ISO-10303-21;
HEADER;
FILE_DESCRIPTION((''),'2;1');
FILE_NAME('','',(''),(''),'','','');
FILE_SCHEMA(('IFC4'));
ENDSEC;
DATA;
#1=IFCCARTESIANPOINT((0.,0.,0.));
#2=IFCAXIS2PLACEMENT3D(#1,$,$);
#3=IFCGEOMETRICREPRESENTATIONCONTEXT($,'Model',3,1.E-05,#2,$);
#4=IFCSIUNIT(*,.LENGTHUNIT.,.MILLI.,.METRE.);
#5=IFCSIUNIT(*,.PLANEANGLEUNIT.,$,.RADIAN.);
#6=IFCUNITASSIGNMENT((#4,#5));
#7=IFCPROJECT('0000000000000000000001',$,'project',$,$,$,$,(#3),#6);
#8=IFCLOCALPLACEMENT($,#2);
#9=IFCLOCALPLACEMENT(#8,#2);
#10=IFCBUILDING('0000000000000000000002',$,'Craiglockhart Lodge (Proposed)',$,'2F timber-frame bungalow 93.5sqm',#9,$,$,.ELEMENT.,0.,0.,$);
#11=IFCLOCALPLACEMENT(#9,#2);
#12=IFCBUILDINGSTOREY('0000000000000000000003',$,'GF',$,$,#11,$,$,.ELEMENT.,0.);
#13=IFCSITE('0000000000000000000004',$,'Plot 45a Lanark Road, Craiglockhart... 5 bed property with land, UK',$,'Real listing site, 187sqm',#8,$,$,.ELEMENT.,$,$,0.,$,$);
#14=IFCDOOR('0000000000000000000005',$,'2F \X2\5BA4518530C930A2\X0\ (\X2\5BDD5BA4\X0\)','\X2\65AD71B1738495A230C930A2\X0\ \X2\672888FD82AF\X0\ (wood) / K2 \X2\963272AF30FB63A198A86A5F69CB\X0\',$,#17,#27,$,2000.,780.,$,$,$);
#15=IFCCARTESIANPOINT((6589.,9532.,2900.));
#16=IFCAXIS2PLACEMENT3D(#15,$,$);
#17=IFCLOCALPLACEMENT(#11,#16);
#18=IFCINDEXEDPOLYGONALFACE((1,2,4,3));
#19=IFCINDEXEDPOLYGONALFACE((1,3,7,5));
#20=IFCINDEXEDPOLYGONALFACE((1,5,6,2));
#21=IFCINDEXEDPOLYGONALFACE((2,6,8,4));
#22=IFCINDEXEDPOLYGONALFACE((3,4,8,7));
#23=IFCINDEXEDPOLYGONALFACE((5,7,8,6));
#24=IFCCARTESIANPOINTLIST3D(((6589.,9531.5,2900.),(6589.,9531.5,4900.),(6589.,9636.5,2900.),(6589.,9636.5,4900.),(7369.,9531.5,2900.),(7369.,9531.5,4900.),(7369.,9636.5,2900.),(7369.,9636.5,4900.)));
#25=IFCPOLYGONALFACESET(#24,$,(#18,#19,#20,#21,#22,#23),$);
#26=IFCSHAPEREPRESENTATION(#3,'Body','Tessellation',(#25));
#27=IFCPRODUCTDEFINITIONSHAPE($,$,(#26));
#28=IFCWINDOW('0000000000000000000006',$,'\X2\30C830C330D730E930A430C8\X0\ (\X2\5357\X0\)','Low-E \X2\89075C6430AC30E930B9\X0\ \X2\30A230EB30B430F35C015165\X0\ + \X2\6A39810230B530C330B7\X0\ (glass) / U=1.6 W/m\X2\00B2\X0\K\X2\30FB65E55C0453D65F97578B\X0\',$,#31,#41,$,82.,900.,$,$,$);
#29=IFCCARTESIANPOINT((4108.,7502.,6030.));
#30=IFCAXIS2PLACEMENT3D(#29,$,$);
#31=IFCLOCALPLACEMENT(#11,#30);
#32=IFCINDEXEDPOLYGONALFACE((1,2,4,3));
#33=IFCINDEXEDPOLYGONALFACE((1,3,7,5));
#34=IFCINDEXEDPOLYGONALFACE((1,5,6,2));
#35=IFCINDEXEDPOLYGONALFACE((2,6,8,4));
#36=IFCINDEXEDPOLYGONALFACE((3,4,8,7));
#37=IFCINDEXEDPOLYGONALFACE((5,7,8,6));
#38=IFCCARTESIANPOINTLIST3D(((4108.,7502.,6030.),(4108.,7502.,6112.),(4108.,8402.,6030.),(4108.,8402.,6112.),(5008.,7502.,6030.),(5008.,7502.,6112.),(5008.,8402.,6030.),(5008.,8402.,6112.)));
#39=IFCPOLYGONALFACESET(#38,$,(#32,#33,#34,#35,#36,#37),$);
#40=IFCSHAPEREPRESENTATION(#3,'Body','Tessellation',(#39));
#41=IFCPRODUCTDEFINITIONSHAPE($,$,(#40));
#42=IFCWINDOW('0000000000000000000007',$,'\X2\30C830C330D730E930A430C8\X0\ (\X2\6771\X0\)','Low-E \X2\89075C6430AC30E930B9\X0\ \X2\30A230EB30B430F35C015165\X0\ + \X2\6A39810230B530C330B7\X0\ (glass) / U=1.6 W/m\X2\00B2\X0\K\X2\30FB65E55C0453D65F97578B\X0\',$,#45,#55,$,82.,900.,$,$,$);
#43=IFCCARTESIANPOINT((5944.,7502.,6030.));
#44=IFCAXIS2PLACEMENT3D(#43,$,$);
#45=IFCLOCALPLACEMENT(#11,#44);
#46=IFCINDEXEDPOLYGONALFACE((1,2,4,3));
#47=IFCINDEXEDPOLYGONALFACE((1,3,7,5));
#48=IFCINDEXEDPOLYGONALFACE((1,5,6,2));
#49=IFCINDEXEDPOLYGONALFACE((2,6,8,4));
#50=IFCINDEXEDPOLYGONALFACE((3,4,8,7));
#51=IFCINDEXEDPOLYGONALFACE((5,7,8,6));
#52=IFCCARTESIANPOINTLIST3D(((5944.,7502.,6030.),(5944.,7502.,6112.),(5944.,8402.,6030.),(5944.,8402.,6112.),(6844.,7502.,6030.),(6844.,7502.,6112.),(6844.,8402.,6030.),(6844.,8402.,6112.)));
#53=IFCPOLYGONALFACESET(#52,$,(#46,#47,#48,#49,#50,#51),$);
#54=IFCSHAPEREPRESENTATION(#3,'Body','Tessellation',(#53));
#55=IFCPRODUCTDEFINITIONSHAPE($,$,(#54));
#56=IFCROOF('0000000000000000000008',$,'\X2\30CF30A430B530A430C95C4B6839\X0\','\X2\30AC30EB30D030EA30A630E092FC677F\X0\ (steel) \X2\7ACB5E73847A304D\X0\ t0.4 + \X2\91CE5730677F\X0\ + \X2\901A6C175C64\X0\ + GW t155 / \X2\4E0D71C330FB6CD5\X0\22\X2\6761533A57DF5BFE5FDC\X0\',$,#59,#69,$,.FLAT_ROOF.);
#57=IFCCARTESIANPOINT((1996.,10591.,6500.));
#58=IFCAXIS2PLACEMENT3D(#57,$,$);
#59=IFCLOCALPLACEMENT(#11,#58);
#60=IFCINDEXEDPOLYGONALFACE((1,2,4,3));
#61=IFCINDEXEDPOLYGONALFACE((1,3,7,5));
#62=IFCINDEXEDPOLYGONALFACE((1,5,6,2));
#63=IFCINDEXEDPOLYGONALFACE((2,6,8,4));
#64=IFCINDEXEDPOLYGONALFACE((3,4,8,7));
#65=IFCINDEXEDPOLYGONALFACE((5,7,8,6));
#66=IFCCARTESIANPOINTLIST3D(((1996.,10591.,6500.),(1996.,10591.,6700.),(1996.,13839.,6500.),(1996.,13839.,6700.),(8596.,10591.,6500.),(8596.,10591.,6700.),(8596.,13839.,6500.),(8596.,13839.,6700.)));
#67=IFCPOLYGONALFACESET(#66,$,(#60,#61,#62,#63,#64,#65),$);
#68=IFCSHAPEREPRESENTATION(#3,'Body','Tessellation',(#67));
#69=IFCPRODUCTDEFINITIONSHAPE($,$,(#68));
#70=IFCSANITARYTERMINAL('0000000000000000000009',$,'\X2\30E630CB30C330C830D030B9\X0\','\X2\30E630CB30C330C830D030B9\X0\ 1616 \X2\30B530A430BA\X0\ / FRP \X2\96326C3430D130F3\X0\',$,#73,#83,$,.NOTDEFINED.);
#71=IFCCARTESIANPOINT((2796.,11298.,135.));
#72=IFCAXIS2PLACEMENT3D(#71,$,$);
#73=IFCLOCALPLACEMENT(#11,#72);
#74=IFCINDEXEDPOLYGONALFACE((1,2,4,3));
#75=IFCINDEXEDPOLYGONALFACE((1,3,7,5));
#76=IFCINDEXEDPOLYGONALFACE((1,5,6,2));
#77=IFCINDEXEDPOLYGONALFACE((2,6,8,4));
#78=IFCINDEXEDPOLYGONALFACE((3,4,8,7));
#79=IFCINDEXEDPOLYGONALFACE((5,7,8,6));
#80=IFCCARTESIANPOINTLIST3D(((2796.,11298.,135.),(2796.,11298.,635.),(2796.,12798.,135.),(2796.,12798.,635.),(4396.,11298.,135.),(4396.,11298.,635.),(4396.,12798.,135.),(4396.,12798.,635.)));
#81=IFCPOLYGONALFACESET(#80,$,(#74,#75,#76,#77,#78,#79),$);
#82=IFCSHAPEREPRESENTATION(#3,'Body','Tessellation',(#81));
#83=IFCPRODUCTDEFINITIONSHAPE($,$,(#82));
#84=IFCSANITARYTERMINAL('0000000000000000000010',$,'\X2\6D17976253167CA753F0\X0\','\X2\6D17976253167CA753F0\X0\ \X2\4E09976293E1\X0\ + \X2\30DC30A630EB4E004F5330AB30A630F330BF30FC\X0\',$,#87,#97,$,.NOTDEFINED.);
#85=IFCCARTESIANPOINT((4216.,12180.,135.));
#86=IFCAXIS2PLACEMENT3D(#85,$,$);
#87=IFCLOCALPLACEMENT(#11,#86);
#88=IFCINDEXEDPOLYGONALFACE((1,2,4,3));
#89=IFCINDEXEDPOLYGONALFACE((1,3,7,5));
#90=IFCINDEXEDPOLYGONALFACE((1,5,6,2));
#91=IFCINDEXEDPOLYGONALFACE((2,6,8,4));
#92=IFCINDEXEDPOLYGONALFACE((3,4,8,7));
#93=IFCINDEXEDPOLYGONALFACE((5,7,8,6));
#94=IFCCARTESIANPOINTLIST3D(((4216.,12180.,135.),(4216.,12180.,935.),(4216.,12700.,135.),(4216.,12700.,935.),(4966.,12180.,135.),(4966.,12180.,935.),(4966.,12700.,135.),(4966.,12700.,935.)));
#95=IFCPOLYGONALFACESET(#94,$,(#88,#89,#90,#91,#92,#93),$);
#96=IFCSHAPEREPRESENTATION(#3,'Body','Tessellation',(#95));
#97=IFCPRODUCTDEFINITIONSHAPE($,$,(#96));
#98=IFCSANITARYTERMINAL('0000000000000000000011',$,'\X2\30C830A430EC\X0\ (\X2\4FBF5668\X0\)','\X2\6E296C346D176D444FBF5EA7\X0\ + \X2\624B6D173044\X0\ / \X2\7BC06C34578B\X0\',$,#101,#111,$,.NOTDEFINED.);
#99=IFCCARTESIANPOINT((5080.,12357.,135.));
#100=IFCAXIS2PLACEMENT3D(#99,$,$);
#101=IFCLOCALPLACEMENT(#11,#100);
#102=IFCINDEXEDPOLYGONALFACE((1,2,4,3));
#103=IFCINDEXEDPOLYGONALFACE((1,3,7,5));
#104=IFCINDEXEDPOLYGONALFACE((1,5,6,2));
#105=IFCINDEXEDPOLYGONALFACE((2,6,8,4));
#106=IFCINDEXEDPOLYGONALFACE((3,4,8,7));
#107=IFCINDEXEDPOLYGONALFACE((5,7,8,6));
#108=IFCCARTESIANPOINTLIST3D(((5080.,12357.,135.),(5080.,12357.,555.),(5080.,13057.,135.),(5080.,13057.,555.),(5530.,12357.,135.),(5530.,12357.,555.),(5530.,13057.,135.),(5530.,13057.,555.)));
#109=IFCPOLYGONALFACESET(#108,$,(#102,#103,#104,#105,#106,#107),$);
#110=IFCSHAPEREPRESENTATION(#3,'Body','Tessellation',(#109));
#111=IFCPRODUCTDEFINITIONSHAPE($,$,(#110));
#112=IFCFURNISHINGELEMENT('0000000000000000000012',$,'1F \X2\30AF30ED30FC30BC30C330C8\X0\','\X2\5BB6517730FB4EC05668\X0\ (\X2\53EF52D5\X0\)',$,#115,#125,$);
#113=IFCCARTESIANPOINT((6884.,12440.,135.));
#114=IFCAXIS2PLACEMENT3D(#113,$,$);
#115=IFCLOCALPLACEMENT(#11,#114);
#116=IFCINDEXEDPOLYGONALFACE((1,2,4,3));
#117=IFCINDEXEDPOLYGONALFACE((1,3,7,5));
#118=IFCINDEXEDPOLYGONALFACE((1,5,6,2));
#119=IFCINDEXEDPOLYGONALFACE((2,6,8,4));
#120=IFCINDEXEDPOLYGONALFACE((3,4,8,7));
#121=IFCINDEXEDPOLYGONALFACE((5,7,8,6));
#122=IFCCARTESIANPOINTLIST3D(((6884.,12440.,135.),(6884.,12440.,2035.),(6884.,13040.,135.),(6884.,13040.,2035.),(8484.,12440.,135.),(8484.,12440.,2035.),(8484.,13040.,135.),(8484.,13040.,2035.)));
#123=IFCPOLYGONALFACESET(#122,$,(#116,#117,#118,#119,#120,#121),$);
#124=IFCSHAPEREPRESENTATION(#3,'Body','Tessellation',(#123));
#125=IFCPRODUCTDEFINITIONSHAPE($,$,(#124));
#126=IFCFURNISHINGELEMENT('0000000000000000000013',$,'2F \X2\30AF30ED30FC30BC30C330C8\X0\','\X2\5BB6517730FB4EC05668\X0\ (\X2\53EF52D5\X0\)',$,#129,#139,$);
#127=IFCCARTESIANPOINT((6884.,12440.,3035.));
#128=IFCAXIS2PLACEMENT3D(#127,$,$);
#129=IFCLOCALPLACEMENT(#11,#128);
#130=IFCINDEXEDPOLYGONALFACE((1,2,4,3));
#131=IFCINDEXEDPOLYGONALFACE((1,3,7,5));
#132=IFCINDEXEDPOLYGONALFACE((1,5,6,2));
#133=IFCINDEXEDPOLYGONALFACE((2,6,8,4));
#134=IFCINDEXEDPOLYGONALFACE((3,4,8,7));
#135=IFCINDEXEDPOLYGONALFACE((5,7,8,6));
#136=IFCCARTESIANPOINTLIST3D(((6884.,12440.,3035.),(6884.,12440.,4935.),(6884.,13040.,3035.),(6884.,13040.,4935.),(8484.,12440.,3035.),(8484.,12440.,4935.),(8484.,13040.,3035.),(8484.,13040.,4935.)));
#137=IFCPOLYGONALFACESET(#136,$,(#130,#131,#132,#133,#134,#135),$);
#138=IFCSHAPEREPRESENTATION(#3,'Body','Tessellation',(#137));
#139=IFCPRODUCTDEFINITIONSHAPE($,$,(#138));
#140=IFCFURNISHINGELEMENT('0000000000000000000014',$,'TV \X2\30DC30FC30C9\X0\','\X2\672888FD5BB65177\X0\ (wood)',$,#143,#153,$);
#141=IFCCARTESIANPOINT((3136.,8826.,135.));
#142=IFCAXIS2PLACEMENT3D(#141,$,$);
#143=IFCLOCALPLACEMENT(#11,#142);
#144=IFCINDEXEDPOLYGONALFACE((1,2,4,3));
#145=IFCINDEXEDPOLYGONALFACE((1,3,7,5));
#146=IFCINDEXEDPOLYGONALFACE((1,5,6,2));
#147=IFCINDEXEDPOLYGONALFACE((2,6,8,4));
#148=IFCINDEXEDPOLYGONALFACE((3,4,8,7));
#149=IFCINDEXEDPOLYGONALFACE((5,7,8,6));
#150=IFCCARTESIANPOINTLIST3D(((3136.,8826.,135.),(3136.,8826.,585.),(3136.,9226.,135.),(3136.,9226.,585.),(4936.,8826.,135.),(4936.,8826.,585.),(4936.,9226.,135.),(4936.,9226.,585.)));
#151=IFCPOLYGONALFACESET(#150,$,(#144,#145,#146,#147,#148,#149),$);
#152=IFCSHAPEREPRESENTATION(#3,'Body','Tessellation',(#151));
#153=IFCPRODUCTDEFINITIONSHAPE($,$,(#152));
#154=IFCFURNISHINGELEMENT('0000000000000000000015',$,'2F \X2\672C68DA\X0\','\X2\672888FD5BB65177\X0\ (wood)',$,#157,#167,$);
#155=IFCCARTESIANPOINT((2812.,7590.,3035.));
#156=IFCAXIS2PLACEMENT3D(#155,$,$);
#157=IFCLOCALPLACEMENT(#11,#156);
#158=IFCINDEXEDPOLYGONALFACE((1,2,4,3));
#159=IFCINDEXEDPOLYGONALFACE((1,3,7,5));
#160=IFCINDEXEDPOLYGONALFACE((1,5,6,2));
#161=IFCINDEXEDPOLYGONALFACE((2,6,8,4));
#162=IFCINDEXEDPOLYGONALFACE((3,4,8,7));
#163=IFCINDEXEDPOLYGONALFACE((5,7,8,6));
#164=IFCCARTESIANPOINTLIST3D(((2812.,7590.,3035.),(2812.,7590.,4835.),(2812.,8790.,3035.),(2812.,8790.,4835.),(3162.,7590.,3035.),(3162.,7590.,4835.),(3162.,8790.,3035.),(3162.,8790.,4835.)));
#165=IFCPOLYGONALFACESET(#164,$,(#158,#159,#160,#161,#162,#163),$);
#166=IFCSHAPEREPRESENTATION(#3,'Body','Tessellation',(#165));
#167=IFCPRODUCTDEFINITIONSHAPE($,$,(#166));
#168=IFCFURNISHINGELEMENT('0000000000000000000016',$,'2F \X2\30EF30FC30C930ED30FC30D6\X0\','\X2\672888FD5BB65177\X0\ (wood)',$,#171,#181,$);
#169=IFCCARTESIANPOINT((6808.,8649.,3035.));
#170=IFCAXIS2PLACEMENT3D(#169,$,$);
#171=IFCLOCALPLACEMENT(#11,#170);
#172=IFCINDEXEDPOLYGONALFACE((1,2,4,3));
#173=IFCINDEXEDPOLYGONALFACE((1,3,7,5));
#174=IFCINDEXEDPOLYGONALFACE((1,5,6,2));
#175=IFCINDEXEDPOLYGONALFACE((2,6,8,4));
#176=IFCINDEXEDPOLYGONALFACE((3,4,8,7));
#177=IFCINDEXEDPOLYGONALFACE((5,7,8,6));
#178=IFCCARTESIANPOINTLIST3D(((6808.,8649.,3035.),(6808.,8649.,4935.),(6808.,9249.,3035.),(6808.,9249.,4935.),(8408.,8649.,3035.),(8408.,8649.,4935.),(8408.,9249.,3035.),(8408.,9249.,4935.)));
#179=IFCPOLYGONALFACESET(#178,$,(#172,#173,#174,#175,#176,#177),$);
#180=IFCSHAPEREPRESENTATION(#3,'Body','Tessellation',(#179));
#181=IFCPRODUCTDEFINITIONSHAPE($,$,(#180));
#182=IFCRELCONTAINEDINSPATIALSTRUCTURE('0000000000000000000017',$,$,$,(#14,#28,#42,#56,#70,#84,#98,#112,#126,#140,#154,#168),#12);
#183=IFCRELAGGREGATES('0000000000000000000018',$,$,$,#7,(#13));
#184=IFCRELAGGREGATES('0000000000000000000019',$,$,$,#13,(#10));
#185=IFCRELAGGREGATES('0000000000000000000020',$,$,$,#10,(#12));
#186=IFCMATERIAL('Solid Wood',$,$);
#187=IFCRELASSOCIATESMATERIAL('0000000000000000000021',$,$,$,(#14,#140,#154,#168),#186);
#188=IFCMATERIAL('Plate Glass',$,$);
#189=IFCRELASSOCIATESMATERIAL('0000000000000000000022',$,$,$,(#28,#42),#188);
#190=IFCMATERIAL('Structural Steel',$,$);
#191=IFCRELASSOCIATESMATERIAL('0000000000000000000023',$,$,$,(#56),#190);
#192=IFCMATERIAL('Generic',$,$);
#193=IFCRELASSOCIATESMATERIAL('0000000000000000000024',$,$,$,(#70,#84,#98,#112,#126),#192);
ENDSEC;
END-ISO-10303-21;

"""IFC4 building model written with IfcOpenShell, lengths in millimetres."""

from ifc_helpers import new_model, si_unit, frame, frame_2d, origin, place, context, project, spatial, rectangle, extrude, material, element, save


model = new_model("IFC4")

# Units and contexts
model_context = context("Model", 3, precision=1e-05, world=origin())
ifc_project = project(units=[si_unit("LENGTHUNIT", "METRE", prefix="MILLI"), si_unit("PLANEANGLEUNIT", "RADIAN")], contexts=[model_context])

# Site, building, storey
site_placement = place(None, origin())
site = spatial("IfcSite", under=ifc_project, at=site_placement, Name="Plot 45a Lanark Road, Craiglockhart... 5 bed property with land, UK", ObjectType="Real listing site, 187sqm", CompositionType="ELEMENT", RefElevation=0.0)
building_placement = place(site_placement, origin())
building = spatial("IfcBuilding", under=site, at=building_placement, Name="Craiglockhart Lodge (Proposed)", ObjectType="2F timber-frame bungalow 93.5sqm", CompositionType="ELEMENT", ElevationOfRefHeight=0.0, ElevationOfTerrain=0.0)
storey_placement = place(building_placement, origin())
storey = spatial("IfcBuildingStorey", under=building, at=storey_placement, Name="GF", CompositionType="ELEMENT", Elevation=0.0)

# Shared definitions
ifc_material_1 = material(Name="Solid Wood")
ifc_material_2 = material(Name="Plate Glass")

# Door
door_1_placement = place(storey_placement, frame((6589.0, 9532.0, 2900.0)))
element("IfcDoor", 1, at=door_1_placement, inside=storey, material=ifc_material_1, Name="2F 室内ドア (寝室)", Description="断熱玄関ドア 木製芯 (wood) / K2 防犯・採風機構", OverallHeight=2000.0, OverallWidth=780.0, context=model_context, shape_type="SweptSolid", body=[
    extrude(rectangle(XDim=780.0, YDim=105.0, at=frame_2d((390.0, 52.0))), frame((6589.0, 9532.0, 2900.0)), (0.0, 0.0, 1.0), 2000.0),
])

# Windows
window_1_placement = place(storey_placement, frame((4108.0, 7502.0, 6030.0)))
element("IfcWindow", 2, at=window_1_placement, inside=storey, material=ifc_material_2, Name="トップライト (南)", Description="Low-E 複層ガラス アルゴン封入 + 樹脂サッシ (glass) / U=1.6 W/m²K・日射取得型", OverallHeight=82.0, OverallWidth=900.0, context=model_context, shape_type="SweptSolid", body=[
    extrude(rectangle(XDim=900.0, YDim=900.0, at=frame_2d((450.0, 450.0))), frame((4108.0, 7502.0, 6030.0)), (0.0, 0.0, 1.0), 82.0),
])
window_2_placement = place(storey_placement, frame((5944.0, 7502.0, 6030.0)))
element("IfcWindow", 3, at=window_2_placement, inside=storey, material=ifc_material_2, Name="トップライト (東)", Description="Low-E 複層ガラス アルゴン封入 + 樹脂サッシ (glass) / U=1.6 W/m²K・日射取得型", OverallHeight=82.0, OverallWidth=900.0, context=model_context, shape_type="SweptSolid", body=[
    extrude(rectangle(XDim=900.0, YDim=900.0, at=frame_2d((450.0, 450.0))), frame((5944.0, 7502.0, 6030.0)), (0.0, 0.0, 1.0), 82.0),
])

# Roof
ifc_material_3 = material(Name="Structural Steel")
roof_placement = place(storey_placement, frame((1996.0, 10591.0, 6500.0)))
element("IfcRoof", 4, at=roof_placement, inside=storey, material=ifc_material_3, Name="ハイサイド屋根", Description="ガルバリウム鋼板 (steel) 立平葺き t0.4 + 野地板 + 通気層 + GW t155 / 不燃・法22条区域対応", PredefinedType="FLAT_ROOF", context=model_context, shape_type="SweptSolid", body=[
    extrude(rectangle(XDim=6600.0, YDim=3248.0, at=frame_2d((3300.0, 1624.0))), frame((1996.0, 10591.0, 6500.0)), (0.0, 0.0, 1.0), 200.0),
])

# Sanitary terminals
ifc_material_4 = material(Name="Generic")
sanitary_terminal_1_placement = place(storey_placement, frame((2796.0, 11298.0, 135.0)))
element("IfcSanitaryTerminal", 5, at=sanitary_terminal_1_placement, inside=storey, material=ifc_material_4, Name="ユニットバス", Description="ユニットバス 1616 サイズ / FRP 防水パン", PredefinedType="NOTDEFINED", context=model_context, shape_type="SweptSolid", body=[
    extrude(rectangle(XDim=1600.0, YDim=1500.0, at=frame_2d((800.0, 750.0))), frame((2796.0, 11298.0, 135.0)), (0.0, 0.0, 1.0), 500.0),
])
sanitary_terminal_2_placement = place(storey_placement, frame((4216.0, 12180.0, 135.0)))
element("IfcSanitaryTerminal", 6, at=sanitary_terminal_2_placement, inside=storey, material=ifc_material_4, Name="洗面化粧台", Description="洗面化粧台 三面鏡 + ボウル一体カウンター", PredefinedType="NOTDEFINED", context=model_context, shape_type="SweptSolid", body=[
    extrude(rectangle(XDim=750.0, YDim=520.0, at=frame_2d((375.0, 260.0))), frame((4216.0, 12180.0, 135.0)), (0.0, 0.0, 1.0), 800.0),
])
sanitary_terminal_3_placement = place(storey_placement, frame((5080.0, 12357.0, 135.0)))
element("IfcSanitaryTerminal", 7, at=sanitary_terminal_3_placement, inside=storey, material=ifc_material_4, Name="トイレ (便器)", Description="温水洗浄便座 + 手洗い / 節水型", PredefinedType="NOTDEFINED", context=model_context, shape_type="SweptSolid", body=[
    extrude(rectangle(XDim=450.0, YDim=700.0, at=frame_2d((225.0, 350.0))), frame((5080.0, 12357.0, 135.0)), (0.0, 0.0, 1.0), 420.0),
])

# Furnishing elements
furnishing_1_placement = place(storey_placement, frame((6884.0, 12440.0, 135.0)))
element("IfcFurnishingElement", 8, at=furnishing_1_placement, inside=storey, material=ifc_material_4, Name="1F クローゼット", Description="家具・什器 (可動)", context=model_context, shape_type="SweptSolid", body=[
    extrude(rectangle(XDim=1600.0, YDim=600.0, at=frame_2d((800.0, 300.0))), frame((6884.0, 12440.0, 135.0)), (0.0, 0.0, 1.0), 1900.0),
])
furnishing_2_placement = place(storey_placement, frame((6884.0, 12440.0, 3035.0)))
element("IfcFurnishingElement", 9, at=furnishing_2_placement, inside=storey, material=ifc_material_4, Name="2F クローゼット", Description="家具・什器 (可動)", context=model_context, shape_type="SweptSolid", body=[
    extrude(rectangle(XDim=1600.0, YDim=600.0, at=frame_2d((800.0, 300.0))), frame((6884.0, 12440.0, 3035.0)), (0.0, 0.0, 1.0), 1900.0),
])
furnishing_3_placement = place(storey_placement, frame((3136.0, 8826.0, 135.0)))
element("IfcFurnishingElement", 10, at=furnishing_3_placement, inside=storey, material=ifc_material_1, Name="TV ボード", Description="木製家具 (wood)", context=model_context, shape_type="SweptSolid", body=[
    extrude(rectangle(XDim=1800.0, YDim=400.0, at=frame_2d((900.0, 200.0))), frame((3136.0, 8826.0, 135.0)), (0.0, 0.0, 1.0), 450.0),
])
furnishing_4_placement = place(storey_placement, frame((2812.0, 7590.0, 3035.0)))
element("IfcFurnishingElement", 11, at=furnishing_4_placement, inside=storey, material=ifc_material_1, Name="2F 本棚", Description="木製家具 (wood)", context=model_context, shape_type="SweptSolid", body=[
    extrude(rectangle(XDim=350.0, YDim=1200.0, at=frame_2d((175.0, 600.0))), frame((2812.0, 7590.0, 3035.0)), (0.0, 0.0, 1.0), 1800.0),
])
furnishing_5_placement = place(storey_placement, frame((6808.0, 8649.0, 3035.0)))
element("IfcFurnishingElement", 12, at=furnishing_5_placement, inside=storey, material=ifc_material_1, Name="2F ワードローブ", Description="木製家具 (wood)", context=model_context, shape_type="SweptSolid", body=[
    extrude(rectangle(XDim=1600.0, YDim=600.0, at=frame_2d((800.0, 300.0))), frame((6808.0, 8649.0, 3035.0)), (0.0, 0.0, 1.0), 1900.0),
])

save(model, "model.ifc")
